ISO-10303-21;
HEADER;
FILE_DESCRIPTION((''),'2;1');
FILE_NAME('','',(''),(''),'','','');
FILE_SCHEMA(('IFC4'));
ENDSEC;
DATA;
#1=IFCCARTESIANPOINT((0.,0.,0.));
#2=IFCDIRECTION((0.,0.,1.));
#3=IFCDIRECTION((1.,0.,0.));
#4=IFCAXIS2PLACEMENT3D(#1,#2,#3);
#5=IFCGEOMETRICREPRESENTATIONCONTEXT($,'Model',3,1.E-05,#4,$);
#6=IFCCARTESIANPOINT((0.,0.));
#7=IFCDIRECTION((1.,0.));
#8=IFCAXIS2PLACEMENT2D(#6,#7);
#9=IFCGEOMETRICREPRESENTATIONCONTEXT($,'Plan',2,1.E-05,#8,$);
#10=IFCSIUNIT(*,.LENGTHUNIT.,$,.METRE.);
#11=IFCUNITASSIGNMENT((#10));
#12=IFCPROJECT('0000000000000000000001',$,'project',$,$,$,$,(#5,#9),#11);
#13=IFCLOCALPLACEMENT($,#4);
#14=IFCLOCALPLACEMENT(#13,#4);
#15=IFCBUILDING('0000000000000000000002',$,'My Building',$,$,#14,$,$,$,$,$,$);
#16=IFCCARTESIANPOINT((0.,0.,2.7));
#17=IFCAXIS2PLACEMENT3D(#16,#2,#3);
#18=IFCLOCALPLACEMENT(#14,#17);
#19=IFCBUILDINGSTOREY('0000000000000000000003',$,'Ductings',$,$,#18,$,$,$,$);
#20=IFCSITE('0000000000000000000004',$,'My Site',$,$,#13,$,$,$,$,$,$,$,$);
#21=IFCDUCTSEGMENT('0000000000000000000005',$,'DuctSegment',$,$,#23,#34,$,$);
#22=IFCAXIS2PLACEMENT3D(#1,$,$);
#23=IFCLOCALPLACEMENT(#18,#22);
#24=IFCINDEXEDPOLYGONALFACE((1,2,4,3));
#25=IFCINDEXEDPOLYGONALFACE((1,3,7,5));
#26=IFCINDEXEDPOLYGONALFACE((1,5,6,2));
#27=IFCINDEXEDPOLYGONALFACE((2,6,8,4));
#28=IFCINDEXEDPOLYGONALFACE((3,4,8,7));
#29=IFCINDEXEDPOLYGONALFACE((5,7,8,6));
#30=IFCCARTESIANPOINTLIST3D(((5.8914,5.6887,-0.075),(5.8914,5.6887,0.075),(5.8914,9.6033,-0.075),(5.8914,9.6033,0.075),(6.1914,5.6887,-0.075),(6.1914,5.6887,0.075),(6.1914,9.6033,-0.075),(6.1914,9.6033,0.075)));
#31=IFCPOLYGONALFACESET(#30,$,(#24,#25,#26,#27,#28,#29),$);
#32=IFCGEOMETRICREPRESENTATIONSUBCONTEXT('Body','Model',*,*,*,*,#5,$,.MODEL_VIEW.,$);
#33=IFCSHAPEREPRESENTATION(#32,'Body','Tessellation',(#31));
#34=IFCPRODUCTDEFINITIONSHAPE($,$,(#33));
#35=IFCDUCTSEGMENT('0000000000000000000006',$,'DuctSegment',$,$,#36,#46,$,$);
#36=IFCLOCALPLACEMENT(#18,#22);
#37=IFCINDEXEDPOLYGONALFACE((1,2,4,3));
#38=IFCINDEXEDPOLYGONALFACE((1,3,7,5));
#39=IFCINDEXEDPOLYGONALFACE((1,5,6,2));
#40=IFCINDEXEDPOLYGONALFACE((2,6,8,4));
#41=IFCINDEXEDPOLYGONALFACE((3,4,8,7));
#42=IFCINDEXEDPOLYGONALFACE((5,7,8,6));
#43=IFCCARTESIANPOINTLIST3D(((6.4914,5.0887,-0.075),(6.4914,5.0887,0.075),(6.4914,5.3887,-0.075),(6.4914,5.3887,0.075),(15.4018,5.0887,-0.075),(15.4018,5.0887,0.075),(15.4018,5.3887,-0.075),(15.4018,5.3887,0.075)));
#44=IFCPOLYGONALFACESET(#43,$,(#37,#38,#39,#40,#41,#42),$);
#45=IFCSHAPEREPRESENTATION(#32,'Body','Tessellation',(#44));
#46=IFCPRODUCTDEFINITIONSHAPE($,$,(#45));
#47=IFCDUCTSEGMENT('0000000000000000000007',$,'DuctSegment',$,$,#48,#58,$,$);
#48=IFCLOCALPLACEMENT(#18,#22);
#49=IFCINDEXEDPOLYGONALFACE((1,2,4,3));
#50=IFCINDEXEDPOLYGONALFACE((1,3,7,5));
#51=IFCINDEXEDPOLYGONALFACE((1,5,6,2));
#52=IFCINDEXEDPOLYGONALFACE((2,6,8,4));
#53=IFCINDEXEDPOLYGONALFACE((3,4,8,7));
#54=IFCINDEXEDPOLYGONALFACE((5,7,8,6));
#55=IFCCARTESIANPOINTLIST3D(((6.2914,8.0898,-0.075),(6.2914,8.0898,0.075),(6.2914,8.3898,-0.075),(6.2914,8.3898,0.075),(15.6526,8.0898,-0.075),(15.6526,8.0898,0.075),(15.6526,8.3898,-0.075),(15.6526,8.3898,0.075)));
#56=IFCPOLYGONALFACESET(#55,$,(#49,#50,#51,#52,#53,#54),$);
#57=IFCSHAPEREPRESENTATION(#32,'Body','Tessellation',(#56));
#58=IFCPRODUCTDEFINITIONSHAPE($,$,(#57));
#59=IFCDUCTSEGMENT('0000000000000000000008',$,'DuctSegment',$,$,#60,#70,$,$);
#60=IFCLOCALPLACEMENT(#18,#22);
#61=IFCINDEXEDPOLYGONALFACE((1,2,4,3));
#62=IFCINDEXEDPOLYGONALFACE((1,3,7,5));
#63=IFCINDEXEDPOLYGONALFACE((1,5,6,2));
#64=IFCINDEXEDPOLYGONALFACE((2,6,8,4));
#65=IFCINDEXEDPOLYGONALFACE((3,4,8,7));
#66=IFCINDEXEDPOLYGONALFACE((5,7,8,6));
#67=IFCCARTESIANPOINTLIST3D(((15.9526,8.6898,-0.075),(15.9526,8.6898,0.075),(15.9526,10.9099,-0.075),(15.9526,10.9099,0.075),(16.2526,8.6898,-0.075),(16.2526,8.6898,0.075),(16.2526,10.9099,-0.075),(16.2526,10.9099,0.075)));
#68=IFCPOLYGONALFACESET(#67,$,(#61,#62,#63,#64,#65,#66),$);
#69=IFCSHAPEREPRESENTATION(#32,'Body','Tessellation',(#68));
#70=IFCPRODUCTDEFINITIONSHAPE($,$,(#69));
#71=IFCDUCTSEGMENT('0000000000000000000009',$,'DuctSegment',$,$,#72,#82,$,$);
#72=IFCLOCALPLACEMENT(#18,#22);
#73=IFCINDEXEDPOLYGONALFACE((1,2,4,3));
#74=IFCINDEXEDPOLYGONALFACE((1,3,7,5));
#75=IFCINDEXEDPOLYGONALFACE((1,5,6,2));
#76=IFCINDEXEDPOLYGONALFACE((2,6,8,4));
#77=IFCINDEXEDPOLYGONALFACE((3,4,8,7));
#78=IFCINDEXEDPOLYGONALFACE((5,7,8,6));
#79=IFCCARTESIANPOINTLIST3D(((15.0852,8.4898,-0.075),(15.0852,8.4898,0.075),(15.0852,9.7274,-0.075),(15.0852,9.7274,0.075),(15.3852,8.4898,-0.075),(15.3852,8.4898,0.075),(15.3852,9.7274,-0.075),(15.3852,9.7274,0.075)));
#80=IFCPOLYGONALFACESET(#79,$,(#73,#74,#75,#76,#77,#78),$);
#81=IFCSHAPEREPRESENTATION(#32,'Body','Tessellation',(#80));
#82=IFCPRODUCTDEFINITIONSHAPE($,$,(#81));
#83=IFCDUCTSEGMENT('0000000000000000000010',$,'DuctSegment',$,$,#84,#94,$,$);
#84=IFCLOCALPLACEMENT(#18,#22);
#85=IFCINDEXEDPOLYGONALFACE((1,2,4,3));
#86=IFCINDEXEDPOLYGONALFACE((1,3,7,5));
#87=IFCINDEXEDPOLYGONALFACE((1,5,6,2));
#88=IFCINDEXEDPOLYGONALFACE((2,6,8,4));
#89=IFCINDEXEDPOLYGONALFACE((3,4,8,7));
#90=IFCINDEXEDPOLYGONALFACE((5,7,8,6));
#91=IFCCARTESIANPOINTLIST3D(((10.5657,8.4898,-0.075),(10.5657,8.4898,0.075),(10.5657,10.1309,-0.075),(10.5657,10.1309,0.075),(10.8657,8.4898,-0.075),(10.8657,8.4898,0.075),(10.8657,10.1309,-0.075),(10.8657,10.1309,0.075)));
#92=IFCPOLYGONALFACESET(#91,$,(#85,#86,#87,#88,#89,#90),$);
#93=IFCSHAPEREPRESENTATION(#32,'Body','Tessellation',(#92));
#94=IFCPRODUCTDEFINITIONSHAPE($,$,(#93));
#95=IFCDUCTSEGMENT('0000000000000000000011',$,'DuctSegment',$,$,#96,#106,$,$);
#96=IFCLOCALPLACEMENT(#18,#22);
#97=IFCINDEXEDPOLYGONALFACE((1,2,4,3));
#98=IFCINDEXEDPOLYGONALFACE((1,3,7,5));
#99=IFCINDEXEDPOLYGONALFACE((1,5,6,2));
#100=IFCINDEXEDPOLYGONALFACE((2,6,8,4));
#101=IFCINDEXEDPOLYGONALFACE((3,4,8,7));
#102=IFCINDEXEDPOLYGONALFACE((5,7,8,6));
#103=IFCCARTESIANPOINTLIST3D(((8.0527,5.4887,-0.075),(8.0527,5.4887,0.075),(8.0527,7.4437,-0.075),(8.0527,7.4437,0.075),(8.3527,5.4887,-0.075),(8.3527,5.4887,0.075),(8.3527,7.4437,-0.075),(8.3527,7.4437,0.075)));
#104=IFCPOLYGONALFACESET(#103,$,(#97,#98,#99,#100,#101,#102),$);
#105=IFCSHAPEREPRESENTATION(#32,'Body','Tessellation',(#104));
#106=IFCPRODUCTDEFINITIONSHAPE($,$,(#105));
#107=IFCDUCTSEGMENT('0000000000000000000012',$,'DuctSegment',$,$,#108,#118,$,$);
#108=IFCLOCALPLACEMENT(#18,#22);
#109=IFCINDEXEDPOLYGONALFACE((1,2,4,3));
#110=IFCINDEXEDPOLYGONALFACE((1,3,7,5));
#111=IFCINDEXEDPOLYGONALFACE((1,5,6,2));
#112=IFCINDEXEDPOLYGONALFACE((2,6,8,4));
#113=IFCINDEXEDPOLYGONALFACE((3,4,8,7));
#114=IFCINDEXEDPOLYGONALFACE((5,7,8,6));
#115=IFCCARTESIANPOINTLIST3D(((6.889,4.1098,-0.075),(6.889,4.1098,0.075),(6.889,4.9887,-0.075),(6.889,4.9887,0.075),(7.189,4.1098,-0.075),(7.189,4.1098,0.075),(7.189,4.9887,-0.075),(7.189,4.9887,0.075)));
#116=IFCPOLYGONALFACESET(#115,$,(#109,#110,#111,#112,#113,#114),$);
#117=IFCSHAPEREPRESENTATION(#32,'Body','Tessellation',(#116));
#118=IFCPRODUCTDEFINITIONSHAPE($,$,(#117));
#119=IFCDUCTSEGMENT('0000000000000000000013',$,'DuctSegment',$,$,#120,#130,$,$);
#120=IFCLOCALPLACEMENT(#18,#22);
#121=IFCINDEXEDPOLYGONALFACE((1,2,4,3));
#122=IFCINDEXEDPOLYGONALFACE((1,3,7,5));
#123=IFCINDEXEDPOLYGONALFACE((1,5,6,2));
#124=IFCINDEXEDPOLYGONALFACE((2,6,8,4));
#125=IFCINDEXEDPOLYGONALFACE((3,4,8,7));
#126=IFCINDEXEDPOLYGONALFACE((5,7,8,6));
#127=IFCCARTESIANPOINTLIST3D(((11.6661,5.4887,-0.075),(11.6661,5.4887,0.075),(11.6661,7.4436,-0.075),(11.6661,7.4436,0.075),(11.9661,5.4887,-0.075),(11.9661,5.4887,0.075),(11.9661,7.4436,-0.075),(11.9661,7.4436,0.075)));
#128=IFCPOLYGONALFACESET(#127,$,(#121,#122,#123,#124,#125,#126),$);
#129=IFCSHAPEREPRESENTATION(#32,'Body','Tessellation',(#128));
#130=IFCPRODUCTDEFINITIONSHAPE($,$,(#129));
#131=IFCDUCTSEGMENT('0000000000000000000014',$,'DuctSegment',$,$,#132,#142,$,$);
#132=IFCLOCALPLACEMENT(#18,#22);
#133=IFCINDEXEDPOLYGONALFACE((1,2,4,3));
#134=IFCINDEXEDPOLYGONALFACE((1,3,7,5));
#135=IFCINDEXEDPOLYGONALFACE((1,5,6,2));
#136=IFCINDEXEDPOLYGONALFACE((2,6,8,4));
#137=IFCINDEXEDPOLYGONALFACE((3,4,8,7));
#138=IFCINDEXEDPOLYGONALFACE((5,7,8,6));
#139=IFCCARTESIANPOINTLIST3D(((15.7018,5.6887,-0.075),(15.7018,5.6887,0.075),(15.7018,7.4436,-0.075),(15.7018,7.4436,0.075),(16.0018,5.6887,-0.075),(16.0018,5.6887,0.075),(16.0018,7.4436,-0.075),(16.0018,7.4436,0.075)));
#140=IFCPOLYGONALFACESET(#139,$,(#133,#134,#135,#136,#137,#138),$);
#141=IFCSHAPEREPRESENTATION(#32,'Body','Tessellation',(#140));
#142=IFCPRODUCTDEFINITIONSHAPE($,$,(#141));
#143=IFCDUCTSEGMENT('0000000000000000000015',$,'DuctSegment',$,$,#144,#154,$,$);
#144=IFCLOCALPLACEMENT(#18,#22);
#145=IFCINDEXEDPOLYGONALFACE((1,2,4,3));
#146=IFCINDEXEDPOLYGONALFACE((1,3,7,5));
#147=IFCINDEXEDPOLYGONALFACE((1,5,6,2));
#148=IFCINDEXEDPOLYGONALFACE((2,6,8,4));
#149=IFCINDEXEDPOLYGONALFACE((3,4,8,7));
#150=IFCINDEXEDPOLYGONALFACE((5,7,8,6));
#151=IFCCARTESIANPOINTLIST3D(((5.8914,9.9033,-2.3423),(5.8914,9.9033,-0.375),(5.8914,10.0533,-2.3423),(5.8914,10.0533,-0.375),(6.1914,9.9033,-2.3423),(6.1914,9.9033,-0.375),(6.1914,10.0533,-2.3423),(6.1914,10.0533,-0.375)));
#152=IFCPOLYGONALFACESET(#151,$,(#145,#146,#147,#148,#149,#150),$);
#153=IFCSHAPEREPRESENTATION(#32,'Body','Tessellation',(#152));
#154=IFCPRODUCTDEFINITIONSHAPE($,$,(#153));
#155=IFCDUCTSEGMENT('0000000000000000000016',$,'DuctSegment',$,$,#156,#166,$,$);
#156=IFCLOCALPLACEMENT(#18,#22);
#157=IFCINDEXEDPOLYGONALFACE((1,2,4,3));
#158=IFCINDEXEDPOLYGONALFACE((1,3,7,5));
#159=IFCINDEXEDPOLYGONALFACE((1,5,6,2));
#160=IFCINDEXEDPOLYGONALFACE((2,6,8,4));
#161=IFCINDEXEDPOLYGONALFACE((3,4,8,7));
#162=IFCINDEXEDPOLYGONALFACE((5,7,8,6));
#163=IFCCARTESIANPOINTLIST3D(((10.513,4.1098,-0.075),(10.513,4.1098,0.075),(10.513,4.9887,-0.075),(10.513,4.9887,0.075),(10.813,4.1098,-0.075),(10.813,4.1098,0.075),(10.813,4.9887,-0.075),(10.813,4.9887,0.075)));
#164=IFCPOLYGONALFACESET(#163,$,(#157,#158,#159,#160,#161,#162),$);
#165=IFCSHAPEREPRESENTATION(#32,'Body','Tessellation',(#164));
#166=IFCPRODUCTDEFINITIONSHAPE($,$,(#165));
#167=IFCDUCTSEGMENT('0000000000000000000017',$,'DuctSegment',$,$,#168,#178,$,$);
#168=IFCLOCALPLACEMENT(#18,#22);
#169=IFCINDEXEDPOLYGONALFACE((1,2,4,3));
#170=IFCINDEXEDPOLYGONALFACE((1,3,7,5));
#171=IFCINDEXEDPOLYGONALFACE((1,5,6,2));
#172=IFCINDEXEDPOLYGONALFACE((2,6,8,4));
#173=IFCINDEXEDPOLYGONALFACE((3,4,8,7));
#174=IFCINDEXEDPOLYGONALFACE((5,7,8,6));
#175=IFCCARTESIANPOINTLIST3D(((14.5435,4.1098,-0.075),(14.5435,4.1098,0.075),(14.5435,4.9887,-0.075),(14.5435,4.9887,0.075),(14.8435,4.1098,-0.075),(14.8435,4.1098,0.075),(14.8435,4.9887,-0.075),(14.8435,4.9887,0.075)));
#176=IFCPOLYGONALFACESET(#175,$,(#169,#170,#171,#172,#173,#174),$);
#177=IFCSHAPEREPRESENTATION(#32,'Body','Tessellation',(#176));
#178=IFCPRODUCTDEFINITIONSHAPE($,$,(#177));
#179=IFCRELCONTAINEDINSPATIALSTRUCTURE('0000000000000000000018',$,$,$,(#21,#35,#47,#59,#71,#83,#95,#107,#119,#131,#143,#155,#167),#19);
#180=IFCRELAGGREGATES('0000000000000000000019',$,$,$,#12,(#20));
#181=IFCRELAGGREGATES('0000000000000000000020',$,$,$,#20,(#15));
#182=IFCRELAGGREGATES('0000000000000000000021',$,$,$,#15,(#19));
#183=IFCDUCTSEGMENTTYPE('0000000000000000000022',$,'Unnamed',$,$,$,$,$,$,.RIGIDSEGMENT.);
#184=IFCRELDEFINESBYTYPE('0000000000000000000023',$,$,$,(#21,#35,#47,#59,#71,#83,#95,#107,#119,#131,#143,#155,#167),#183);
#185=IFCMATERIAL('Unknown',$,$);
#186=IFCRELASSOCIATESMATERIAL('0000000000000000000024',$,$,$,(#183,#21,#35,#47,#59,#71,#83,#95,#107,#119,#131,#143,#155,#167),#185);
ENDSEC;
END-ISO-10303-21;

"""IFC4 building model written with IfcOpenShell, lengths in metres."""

from ifc_helpers import new_model, si_unit, frame, origin_with_axes, origin_2d_with_axis, place, context, subcontext, project, spatial, rectangle, extrude, material, material_profile, profile_set, profile_usage, type_object, element, save


model = new_model("IFC4")

# Units and contexts
model_context = context("Model", 3, precision=1e-05, world=origin_with_axes())
plan_context = context("Plan", 2, precision=1e-05, world=origin_2d_with_axis())
body_context = subcontext(model_context, "Body", "Model", "MODEL_VIEW")
ifc_project = project(units=[si_unit("LENGTHUNIT", "METRE")], contexts=[model_context, plan_context])

# Site, building, storey
site_placement = place(None, origin_with_axes())
site = spatial("IfcSite", under=ifc_project, at=site_placement, Name="My Site")
building_placement = place(site_placement, origin_with_axes())
building = spatial("IfcBuilding", under=site, at=building_placement, Name="My Building")
storey_placement = place(building_placement, frame((0.0, 0.0, 2.7), z_axis=(0.0, 0.0, 1.0), x_axis=(1.0, 0.0, 0.0)))
storey = spatial("IfcBuildingStorey", under=building, at=storey_placement, Name="Ductings")

# Duct segments
ifc_material = material(Name="Unknown")
ifc_material_profile_1 = material_profile(ifc_material, rectangle(XDim=0.3, YDim=0.15))
ifc_profile_set_1 = profile_set([ifc_material_profile_1])
ifc_profile_usage_1 = profile_usage(ifc_profile_set_1, cardinal=5)
duct_segment_type = type_object("IfcDuctSegmentType", Name="Unnamed", PredefinedType="RIGIDSEGMENT", material=ifc_profile_set_1)
duct_segment_1_placement = place(storey_placement, frame((6.0414, 9.6033, 0.0), z_axis=(0.0, -1.0, 0.0), x_axis=(1.0, 0.0, 0.0)))
element("IfcDuctSegment", 1, at=duct_segment_1_placement, inside=storey, type_object=duct_segment_type, material=ifc_profile_usage_1, Name="DuctSegment", context=body_context, shape_type="SweptSolid", body=[
    extrude(rectangle(XDim=0.3, YDim=0.15), origin_with_axes(), (0.0, 0.0, 1.0), 3.9146),
])
ifc_profile_usage_2 = profile_usage(ifc_profile_set_1, cardinal=5)
duct_segment_2_placement = place(storey_placement, frame((6.4914, 5.2387, 0.0), z_axis=(1.0, 0.0, 0.0), x_axis=(0.0, 1.0, 0.0)))
element("IfcDuctSegment", 2, at=duct_segment_2_placement, inside=storey, type_object=duct_segment_type, material=ifc_profile_usage_2, Name="DuctSegment", context=body_context, shape_type="SweptSolid", body=[
    extrude(rectangle(XDim=0.3, YDim=0.15), origin_with_axes(), (0.0, 0.0, 1.0), 8.9104),
])
ifc_profile_usage_3 = profile_usage(ifc_profile_set_1, cardinal=5)
duct_segment_3_placement = place(storey_placement, frame((6.2914, 8.2398, 0.0), z_axis=(1.0, 0.0, 0.0), x_axis=(0.0, 1.0, 0.0)))
element("IfcDuctSegment", 3, at=duct_segment_3_placement, inside=storey, type_object=duct_segment_type, material=ifc_profile_usage_3, Name="DuctSegment", context=body_context, shape_type="SweptSolid", body=[
    extrude(rectangle(XDim=0.3, YDim=0.15), origin_with_axes(), (0.0, 0.0, 1.0), 9.3612),
])
ifc_profile_usage_4 = profile_usage(ifc_profile_set_1, cardinal=5)
duct_segment_4_placement = place(storey_placement, frame((16.1026, 8.6898, 0.0), z_axis=(0.0, 1.0, 0.0), x_axis=(-1.0, 0.0, 0.0)))
element("IfcDuctSegment", 4, at=duct_segment_4_placement, inside=storey, type_object=duct_segment_type, material=ifc_profile_usage_4, Name="DuctSegment", context=body_context, shape_type="SweptSolid", body=[
    extrude(rectangle(XDim=0.3, YDim=0.15), origin_with_axes(), (0.0, 0.0, 1.0), 2.2201),
])
ifc_profile_usage_5 = profile_usage(ifc_profile_set_1, cardinal=5)
duct_segment_5_placement = place(storey_placement, frame((15.2352, 8.4898, 0.0), z_axis=(0.0, 1.0, 0.0), x_axis=(-1.0, 0.0, 0.0)))
element("IfcDuctSegment", 5, at=duct_segment_5_placement, inside=storey, type_object=duct_segment_type, material=ifc_profile_usage_5, Name="DuctSegment", context=body_context, shape_type="SweptSolid", body=[
    extrude(rectangle(XDim=0.3, YDim=0.15), origin_with_axes(), (0.0, 0.0, 1.0), 1.2377),
])
ifc_profile_usage_6 = profile_usage(ifc_profile_set_1, cardinal=5)
duct_segment_6_placement = place(storey_placement, frame((10.7157, 8.4898, 0.0), z_axis=(0.0, 1.0, 0.0), x_axis=(-1.0, 0.0, 0.0)))
element("IfcDuctSegment", 6, at=duct_segment_6_placement, inside=storey, type_object=duct_segment_type, material=ifc_profile_usage_6, Name="DuctSegment", context=body_context, shape_type="SweptSolid", body=[
    extrude(rectangle(XDim=0.3, YDim=0.15), origin_with_axes(), (0.0, 0.0, 1.0), 1.6411),
])
ifc_profile_usage_7 = profile_usage(ifc_profile_set_1, cardinal=5)
duct_segment_7_placement = place(storey_placement, frame((8.2027, 5.4887, 0.0), z_axis=(0.0, 1.0, 0.0), x_axis=(-1.0, 0.0, 0.0)))
element("IfcDuctSegment", 7, at=duct_segment_7_placement, inside=storey, type_object=duct_segment_type, material=ifc_profile_usage_7, Name="DuctSegment", context=body_context, shape_type="SweptSolid", body=[
    extrude(rectangle(XDim=0.3, YDim=0.15), origin_with_axes(), (0.0, 0.0, 1.0), 1.955),
])
ifc_profile_usage_8 = profile_usage(ifc_profile_set_1, cardinal=5)
duct_segment_8_placement = place(storey_placement, frame((7.039, 4.9887, 0.0), z_axis=(0.0, -1.0, 0.0), x_axis=(1.0, 0.0, 0.0)))
element("IfcDuctSegment", 8, at=duct_segment_8_placement, inside=storey, type_object=duct_segment_type, material=ifc_profile_usage_8, Name="DuctSegment", context=body_context, shape_type="SweptSolid", body=[
    extrude(rectangle(XDim=0.3, YDim=0.15), origin_with_axes(), (0.0, 0.0, 1.0), 0.8789),
])
ifc_profile_usage_9 = profile_usage(ifc_profile_set_1, cardinal=5)
duct_segment_9_placement = place(storey_placement, frame((11.8161, 5.4887, 0.0), z_axis=(0.0, 1.0, 0.0), x_axis=(-1.0, 0.0, 0.0)))
element("IfcDuctSegment", 9, at=duct_segment_9_placement, inside=storey, type_object=duct_segment_type, material=ifc_profile_usage_9, Name="DuctSegment", context=body_context, shape_type="SweptSolid", body=[
    extrude(rectangle(XDim=0.3, YDim=0.15), origin_with_axes(), (0.0, 0.0, 1.0), 1.955),
])
ifc_profile_usage_10 = profile_usage(ifc_profile_set_1, cardinal=5)
duct_segment_10_placement = place(storey_placement, frame((15.8518, 5.6887, 0.0), z_axis=(0.0, 1.0, 0.0), x_axis=(-1.0, 0.0, 0.0)))
element("IfcDuctSegment", 10, at=duct_segment_10_placement, inside=storey, type_object=duct_segment_type, material=ifc_profile_usage_10, Name="DuctSegment", context=body_context, shape_type="SweptSolid", body=[
    extrude(rectangle(XDim=0.3, YDim=0.15), origin_with_axes(), (0.0, 0.0, 1.0), 1.755),
])
ifc_profile_usage_11 = profile_usage(ifc_profile_set_1, cardinal=5)
duct_segment_11_placement = place(storey_placement, frame((6.0414, 9.9783, -0.375), z_axis=(0.0, 0.0, -1.0), x_axis=(-1.0, 0.0, 0.0)))
element("IfcDuctSegment", 11, at=duct_segment_11_placement, inside=storey, type_object=duct_segment_type, material=ifc_profile_usage_11, Name="DuctSegment", context=body_context, shape_type="SweptSolid", body=[
    extrude(rectangle(XDim=0.3, YDim=0.15), origin_with_axes(), (0.0, 0.0, 1.0), 1.9673),
])
ifc_profile_usage_12 = profile_usage(ifc_profile_set_1, cardinal=5)
duct_segment_12_placement = place(storey_placement, frame((10.663, 4.9887, 0.0), z_axis=(0.0, -1.0, 0.0), x_axis=(1.0, 0.0, 0.0)))
element("IfcDuctSegment", 12, at=duct_segment_12_placement, inside=storey, type_object=duct_segment_type, material=ifc_profile_usage_12, Name="DuctSegment", context=body_context, shape_type="SweptSolid", body=[
    extrude(rectangle(XDim=0.3, YDim=0.15), origin_with_axes(), (0.0, 0.0, 1.0), 0.8789),
])
ifc_profile_usage_13 = profile_usage(ifc_profile_set_1, cardinal=5)
duct_segment_13_placement = place(storey_placement, frame((14.6935, 4.9887, 0.0), z_axis=(0.0, -1.0, 0.0), x_axis=(1.0, 0.0, 0.0)))
element("IfcDuctSegment", 13, at=duct_segment_13_placement, inside=storey, type_object=duct_segment_type, material=ifc_profile_usage_13, Name="DuctSegment", context=body_context, shape_type="SweptSolid", body=[
    extrude(rectangle(XDim=0.3, YDim=0.15), origin_with_axes(), (0.0, 0.0, 1.0), 0.8789),
])

save(model, "model.ifc")
